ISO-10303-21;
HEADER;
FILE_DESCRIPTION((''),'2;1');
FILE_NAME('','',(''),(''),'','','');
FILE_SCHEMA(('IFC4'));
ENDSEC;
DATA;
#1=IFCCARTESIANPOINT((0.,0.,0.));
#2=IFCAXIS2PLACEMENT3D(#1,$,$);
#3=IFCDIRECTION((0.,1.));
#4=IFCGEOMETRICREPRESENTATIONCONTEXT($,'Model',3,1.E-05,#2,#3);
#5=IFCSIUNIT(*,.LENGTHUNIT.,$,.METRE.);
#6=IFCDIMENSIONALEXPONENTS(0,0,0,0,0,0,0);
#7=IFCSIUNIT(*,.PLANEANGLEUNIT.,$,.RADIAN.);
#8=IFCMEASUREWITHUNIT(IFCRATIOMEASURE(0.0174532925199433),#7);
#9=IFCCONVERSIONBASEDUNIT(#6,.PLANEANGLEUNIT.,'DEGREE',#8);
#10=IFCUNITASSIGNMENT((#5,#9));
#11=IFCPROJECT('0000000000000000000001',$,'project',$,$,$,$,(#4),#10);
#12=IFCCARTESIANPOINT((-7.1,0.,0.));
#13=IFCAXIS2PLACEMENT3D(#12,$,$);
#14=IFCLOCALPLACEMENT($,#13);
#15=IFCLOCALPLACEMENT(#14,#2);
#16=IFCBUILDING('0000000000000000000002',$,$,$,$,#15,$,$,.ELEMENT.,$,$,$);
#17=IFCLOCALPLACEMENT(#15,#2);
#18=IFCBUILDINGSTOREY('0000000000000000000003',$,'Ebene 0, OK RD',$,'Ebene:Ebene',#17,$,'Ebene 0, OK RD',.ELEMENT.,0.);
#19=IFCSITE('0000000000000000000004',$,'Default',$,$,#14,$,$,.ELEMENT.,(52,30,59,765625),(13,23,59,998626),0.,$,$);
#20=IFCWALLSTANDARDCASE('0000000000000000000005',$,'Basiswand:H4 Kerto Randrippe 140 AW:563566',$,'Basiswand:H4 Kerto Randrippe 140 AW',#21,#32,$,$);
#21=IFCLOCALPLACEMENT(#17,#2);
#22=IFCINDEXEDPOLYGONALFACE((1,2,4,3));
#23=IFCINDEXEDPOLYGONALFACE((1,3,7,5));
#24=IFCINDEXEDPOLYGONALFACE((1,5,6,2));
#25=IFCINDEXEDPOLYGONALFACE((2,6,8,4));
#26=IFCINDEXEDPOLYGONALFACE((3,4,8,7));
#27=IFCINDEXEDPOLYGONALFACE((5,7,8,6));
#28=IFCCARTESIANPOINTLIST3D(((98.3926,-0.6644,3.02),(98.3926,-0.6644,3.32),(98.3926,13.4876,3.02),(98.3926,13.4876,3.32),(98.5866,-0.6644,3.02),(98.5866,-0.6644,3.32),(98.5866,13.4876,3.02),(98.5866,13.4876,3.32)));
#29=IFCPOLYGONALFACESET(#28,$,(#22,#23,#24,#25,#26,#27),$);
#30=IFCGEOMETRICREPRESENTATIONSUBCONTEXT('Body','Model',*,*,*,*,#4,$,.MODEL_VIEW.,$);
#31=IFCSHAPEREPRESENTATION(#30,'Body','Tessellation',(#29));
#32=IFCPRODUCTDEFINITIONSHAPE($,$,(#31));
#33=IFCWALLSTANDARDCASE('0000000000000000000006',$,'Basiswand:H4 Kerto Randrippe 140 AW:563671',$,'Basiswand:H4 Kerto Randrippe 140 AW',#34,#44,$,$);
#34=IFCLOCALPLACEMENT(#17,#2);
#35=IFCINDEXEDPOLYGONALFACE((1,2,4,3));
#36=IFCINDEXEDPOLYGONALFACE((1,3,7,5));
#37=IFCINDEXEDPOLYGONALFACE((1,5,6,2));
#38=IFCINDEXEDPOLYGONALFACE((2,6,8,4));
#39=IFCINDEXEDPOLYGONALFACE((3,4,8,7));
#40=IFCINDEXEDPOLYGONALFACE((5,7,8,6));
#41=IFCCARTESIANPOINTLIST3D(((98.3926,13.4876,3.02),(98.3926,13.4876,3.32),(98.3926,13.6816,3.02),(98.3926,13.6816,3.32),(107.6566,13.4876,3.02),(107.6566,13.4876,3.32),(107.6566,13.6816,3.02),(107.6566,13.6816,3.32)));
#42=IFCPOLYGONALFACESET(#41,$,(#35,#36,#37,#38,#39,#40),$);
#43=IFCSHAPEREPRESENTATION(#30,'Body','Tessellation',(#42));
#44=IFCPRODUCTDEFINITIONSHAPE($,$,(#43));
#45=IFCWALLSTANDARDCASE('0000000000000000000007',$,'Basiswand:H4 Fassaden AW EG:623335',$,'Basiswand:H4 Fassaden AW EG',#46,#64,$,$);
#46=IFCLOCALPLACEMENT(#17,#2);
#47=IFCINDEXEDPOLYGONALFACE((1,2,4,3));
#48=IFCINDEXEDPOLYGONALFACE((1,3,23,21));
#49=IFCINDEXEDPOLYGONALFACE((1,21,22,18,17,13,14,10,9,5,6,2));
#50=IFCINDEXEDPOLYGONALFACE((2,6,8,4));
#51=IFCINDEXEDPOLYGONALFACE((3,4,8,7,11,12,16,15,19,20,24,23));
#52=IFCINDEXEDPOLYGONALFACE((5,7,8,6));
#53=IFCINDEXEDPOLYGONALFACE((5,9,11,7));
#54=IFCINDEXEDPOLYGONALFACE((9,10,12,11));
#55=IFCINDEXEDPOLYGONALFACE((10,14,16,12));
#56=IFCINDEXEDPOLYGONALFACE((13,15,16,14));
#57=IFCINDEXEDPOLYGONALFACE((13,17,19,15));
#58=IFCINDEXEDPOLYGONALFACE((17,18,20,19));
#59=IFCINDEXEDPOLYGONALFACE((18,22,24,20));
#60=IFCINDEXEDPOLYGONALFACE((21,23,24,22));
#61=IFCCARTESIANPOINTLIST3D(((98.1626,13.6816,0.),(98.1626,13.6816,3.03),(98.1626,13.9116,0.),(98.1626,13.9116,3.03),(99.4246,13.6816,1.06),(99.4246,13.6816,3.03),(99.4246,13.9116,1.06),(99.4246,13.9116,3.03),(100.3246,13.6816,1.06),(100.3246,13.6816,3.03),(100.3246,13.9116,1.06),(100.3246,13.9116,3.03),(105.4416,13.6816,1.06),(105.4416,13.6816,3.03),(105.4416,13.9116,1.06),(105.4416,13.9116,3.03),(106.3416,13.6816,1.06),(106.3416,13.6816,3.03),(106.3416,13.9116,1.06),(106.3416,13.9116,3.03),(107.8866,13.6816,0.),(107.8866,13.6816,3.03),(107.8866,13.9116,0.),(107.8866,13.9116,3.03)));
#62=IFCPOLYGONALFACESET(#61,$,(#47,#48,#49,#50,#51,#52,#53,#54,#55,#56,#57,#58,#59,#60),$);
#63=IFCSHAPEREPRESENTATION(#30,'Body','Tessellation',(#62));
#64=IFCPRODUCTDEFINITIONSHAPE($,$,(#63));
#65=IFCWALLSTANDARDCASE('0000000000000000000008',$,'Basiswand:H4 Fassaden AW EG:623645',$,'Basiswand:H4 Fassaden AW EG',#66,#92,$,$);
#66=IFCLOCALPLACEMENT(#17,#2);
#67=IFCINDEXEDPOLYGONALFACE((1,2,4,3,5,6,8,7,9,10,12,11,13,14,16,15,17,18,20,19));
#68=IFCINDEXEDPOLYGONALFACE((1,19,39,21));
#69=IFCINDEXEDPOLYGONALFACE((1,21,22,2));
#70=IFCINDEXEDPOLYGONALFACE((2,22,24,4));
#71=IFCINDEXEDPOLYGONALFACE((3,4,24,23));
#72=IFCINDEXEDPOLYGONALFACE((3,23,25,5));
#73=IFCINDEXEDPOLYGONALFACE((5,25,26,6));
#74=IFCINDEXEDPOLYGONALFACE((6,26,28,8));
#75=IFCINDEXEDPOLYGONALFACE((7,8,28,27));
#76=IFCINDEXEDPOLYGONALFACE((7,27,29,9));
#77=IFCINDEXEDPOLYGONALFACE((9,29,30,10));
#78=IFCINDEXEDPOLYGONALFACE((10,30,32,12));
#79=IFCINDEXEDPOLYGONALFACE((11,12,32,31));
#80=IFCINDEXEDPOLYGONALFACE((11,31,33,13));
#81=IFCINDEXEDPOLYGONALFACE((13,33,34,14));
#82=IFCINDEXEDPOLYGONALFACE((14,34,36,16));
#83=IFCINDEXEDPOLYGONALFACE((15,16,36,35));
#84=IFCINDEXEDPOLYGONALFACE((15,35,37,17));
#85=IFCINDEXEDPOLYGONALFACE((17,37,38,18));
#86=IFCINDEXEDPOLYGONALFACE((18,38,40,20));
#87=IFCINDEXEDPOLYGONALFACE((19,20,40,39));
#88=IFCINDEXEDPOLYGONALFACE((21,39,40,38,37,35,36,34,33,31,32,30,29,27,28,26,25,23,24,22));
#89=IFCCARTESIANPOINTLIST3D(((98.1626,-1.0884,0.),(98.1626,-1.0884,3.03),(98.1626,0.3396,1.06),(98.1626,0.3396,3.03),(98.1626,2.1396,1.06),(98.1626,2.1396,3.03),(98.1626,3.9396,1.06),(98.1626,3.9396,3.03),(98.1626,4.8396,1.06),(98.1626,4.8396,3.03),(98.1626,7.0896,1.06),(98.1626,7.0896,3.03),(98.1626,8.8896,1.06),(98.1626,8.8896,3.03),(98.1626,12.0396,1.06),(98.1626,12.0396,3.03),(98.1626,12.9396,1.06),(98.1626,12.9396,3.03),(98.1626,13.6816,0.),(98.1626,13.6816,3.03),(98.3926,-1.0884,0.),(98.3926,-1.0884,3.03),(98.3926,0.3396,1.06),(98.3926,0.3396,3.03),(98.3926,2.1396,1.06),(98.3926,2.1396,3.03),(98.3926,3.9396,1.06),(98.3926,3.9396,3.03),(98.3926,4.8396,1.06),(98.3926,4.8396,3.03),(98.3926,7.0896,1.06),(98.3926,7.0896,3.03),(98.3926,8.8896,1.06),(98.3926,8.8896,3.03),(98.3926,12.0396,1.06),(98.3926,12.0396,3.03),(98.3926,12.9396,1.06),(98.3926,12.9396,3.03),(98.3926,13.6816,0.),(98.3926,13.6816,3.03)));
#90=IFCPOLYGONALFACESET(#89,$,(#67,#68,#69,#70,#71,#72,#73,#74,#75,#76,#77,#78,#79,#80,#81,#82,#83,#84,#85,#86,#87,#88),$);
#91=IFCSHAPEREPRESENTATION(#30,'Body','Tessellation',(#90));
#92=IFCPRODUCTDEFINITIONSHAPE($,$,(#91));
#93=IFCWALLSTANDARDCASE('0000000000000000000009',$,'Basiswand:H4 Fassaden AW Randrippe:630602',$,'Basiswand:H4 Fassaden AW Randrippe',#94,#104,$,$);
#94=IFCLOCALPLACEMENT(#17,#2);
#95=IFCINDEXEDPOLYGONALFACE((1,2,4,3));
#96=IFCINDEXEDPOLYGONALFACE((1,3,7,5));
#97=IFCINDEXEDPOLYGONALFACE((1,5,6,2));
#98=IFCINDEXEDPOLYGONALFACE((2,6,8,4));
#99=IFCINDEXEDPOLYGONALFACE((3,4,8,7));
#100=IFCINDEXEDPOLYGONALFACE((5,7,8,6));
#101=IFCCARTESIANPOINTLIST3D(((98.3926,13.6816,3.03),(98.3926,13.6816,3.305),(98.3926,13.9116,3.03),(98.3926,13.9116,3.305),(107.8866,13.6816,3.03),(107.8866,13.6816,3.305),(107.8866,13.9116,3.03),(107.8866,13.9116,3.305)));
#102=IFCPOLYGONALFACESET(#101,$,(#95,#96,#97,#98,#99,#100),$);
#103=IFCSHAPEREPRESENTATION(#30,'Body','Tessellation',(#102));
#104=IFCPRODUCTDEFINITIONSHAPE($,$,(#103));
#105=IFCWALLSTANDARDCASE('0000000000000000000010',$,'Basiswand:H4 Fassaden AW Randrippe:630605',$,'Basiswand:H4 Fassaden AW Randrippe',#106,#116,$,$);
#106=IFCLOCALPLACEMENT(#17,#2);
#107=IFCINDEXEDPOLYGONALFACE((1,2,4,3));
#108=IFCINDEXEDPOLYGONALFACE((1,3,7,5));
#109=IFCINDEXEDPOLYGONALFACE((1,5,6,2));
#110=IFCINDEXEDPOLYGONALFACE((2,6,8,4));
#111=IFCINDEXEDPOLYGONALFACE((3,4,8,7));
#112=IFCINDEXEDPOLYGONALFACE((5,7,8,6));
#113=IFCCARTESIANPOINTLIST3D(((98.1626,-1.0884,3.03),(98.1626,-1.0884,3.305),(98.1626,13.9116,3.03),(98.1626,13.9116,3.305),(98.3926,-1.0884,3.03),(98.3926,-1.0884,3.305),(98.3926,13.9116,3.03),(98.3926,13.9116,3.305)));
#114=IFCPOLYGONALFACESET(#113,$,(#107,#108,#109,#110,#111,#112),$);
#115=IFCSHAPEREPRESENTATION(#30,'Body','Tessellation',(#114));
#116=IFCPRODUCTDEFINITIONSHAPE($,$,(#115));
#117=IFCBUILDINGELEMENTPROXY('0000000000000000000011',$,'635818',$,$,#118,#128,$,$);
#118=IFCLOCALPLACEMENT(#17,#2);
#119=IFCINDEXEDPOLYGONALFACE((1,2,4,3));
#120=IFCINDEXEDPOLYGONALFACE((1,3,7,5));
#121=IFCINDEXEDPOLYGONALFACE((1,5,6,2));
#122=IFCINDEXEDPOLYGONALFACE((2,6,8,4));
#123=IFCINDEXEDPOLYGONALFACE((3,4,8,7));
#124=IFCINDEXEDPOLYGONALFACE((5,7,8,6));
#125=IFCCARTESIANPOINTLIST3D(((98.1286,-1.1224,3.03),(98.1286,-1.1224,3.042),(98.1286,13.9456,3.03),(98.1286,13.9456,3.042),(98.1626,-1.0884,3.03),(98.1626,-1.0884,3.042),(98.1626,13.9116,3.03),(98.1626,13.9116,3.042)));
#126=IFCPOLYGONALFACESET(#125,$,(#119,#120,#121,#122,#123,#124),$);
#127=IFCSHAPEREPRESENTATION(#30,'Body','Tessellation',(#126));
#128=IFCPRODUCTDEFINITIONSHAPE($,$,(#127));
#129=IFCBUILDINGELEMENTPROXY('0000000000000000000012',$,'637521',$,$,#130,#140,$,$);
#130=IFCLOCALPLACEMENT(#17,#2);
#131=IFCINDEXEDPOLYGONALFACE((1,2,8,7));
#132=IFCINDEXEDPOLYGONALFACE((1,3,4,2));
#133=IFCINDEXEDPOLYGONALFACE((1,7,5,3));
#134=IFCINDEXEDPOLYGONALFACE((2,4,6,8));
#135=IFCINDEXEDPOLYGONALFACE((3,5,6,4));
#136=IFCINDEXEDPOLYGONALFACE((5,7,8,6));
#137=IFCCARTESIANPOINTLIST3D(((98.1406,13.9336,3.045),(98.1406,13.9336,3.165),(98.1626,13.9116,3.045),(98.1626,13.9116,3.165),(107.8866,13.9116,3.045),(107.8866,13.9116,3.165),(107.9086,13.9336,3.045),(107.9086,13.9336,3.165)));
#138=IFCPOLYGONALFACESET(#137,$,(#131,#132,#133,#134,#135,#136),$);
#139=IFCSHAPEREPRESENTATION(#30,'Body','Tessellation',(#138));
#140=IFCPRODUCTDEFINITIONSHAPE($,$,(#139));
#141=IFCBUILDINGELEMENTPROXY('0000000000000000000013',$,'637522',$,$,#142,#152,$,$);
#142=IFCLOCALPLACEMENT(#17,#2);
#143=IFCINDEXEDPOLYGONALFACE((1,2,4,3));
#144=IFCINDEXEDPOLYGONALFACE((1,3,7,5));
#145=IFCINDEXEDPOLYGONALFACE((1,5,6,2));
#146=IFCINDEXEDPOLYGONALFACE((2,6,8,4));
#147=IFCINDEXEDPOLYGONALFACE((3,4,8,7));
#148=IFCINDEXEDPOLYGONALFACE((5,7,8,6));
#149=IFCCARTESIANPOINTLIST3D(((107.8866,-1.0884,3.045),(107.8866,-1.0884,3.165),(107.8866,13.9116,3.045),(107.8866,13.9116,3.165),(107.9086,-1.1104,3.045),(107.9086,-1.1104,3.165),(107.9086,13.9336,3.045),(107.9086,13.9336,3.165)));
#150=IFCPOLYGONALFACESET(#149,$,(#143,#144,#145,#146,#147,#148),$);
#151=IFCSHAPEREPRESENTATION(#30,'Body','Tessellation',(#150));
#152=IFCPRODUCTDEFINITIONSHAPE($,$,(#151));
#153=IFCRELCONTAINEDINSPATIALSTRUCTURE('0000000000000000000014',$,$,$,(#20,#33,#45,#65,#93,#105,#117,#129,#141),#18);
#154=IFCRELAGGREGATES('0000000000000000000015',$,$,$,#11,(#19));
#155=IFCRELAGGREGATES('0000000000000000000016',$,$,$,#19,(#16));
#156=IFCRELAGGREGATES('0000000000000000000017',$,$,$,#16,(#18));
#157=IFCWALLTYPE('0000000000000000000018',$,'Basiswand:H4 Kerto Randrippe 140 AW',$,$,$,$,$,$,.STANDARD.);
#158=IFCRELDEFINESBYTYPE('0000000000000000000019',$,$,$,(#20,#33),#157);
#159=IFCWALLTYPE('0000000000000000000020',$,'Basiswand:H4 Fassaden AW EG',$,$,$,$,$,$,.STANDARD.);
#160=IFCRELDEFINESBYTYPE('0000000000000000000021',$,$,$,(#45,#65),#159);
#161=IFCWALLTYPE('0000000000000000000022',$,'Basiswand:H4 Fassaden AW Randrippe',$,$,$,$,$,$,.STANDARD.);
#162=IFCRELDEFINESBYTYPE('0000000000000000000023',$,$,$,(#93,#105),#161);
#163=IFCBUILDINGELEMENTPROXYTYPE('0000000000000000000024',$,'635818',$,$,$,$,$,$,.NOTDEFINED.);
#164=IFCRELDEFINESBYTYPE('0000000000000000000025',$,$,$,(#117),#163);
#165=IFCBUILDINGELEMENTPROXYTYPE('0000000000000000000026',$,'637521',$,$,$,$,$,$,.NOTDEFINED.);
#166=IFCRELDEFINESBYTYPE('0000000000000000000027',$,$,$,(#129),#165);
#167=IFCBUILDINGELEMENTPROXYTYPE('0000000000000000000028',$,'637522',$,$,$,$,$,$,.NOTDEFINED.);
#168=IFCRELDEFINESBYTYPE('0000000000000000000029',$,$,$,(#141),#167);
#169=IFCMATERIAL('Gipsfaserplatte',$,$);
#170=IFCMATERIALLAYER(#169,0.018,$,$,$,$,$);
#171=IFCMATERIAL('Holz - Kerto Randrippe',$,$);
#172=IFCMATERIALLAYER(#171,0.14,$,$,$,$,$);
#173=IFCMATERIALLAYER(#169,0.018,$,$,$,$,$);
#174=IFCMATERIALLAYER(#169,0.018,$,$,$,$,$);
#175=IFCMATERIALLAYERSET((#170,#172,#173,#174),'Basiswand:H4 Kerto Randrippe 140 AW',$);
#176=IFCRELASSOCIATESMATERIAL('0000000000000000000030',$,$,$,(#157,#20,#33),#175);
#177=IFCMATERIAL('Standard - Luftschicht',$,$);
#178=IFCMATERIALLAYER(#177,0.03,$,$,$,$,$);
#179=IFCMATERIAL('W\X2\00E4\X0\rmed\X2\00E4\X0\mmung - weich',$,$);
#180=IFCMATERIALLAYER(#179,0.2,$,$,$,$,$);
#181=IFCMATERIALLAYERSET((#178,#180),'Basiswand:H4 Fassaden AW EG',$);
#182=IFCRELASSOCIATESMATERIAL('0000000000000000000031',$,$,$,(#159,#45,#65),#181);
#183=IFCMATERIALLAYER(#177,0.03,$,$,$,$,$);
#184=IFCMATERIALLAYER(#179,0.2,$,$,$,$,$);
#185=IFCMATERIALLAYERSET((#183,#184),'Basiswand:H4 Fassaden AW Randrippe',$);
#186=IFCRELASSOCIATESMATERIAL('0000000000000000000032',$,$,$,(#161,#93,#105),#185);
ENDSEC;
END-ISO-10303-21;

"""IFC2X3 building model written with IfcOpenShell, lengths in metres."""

from ifc_helpers import new_model, entity, si_unit, converted_unit, direction, frame, frame_2d, origin, place, context, subcontext, project, spatial, polyline, rectangle, outline, extrude, material, layer, layer_set, layer_usage, type_object, element, save


model = new_model("IFC2X3")

# Units and contexts
model_context = context("Model", 3, precision=1e-05, world=origin(), true_north=direction((0.0, 1.0)))
body_context = subcontext(model_context, "Body", "Model", "MODEL_VIEW")
ifc_project = project(units=[si_unit("LENGTHUNIT", "METRE"), converted_unit("PLANEANGLEUNIT", "DEGREE", entity("IfcRatioMeasure", 0.0174532925199433), si_unit("PLANEANGLEUNIT", "RADIAN"), dimensions=[0, 0, 0, 0, 0, 0, 0])], contexts=[model_context])

# Site, building, storey
site_placement = place(None, frame((-7.1, 0.0, 0.0)))
site = spatial("IfcSite", under=ifc_project, at=site_placement, Name="Default", CompositionType="ELEMENT", RefLatitude=(52, 30, 59, 765625), RefLongitude=(13, 23, 59, 998626), RefElevation=0.0)
building_placement = place(site_placement, origin())
building = spatial("IfcBuilding", under=site, at=building_placement, CompositionType="ELEMENT")
storey_placement = place(building_placement, origin())
storey = spatial("IfcBuildingStorey", under=building, at=storey_placement, Name="Ebene 0, OK RD", ObjectType="Ebene:Ebene", LongName="Ebene 0, OK RD", CompositionType="ELEMENT", Elevation=0.0)

# Shared definitions
ifc_material_1 = material(Name="Gipsfaserplatte")

# Walls
ifc_layer_1 = layer(ifc_material_1, 0.018)
ifc_material_2 = material(Name="Holz - Kerto Randrippe")
ifc_layer_2 = layer(ifc_material_2, 0.14)
ifc_layer_3 = layer(ifc_material_1, 0.018)
ifc_layer_4 = layer(ifc_material_1, 0.018)
ifc_layer_set_1 = layer_set([ifc_layer_1, ifc_layer_2, ifc_layer_3, ifc_layer_4], Name="Basiswand:H4 Kerto Randrippe 140 AW")
ifc_layer_usage_1 = layer_usage(ifc_layer_set_1, "AXIS2", "NEGATIVE", 0.097)
wall_type_1 = type_object("IfcWallType", Name="Basiswand:H4 Kerto Randrippe 140 AW", PredefinedType="STANDARD", material=ifc_layer_set_1)
wall_1_placement = place(storey_placement, frame((98.4896, -0.6644, 3.02), z_axis=(0.0, 0.0, 1.0), x_axis=(0.0, 1.0, 0.0)))
element("IfcWallStandardCase", 1, at=wall_1_placement, inside=storey, type_object=wall_type_1, material=ifc_layer_usage_1, Name="Basiswand:H4 Kerto Randrippe 140 AW:563566", ObjectType="Basiswand:H4 Kerto Randrippe 140 AW", context=body_context, shape_type="SweptSolid", body=[
    extrude(rectangle(XDim=14.152, YDim=0.194, at=frame_2d((7.076, 0.0), x_axis=(-1.0, 0.0))), origin(), (0.0, 0.0, 1.0), 0.3),
])
ifc_layer_usage_2 = layer_usage(ifc_layer_set_1, "AXIS2", "NEGATIVE", 0.097)
wall_2_placement = place(storey_placement, frame((98.3926, 13.5846, 3.02)))
element("IfcWallStandardCase", 2, at=wall_2_placement, inside=storey, type_object=wall_type_1, material=ifc_layer_usage_2, Name="Basiswand:H4 Kerto Randrippe 140 AW:563671", ObjectType="Basiswand:H4 Kerto Randrippe 140 AW", context=body_context, shape_type="SweptSolid", body=[
    extrude(rectangle(XDim=9.264, YDim=0.194, at=frame_2d((4.632, 0.0), x_axis=(-1.0, 0.0))), origin(), (0.0, 0.0, 1.0), 0.3),
])

# Walls, openings
ifc_material_3 = material(Name="Standard - Luftschicht")
ifc_layer_5 = layer(ifc_material_3, 0.03)
ifc_material_4 = material(Name="Wärmedämmung - weich")
ifc_layer_6 = layer(ifc_material_4, 0.2)
ifc_layer_set_2 = layer_set([ifc_layer_5, ifc_layer_6], Name="Basiswand:H4 Fassaden AW EG")
ifc_layer_usage_3 = layer_usage(ifc_layer_set_2, "AXIS2", "NEGATIVE", 0.115)
wall_type_2 = type_object("IfcWallType", Name="Basiswand:H4 Fassaden AW EG", PredefinedType="STANDARD", material=ifc_layer_set_2)
wall_3_placement = place(storey_placement, frame((98.1626, 13.7966, 0.0)))
wall_3 = element("IfcWallStandardCase", 3, at=wall_3_placement, inside=storey, type_object=wall_type_2, material=ifc_layer_usage_3, Name="Basiswand:H4 Fassaden AW EG:623335", ObjectType="Basiswand:H4 Fassaden AW EG", context=body_context, shape_type="SweptSolid", body=[
    extrude(rectangle(XDim=9.724, YDim=0.23, at=frame_2d((4.862, 0.0), x_axis=(-1.0, 0.0))), origin(), (0.0, 0.0, 1.0), 3.03),
])
opening_1_placement = place(wall_3_placement, frame((2.162, 0.115, 1.06)))
element("IfcOpeningElement", 4, at=opening_1_placement, cuts=wall_3, ObjectType="Opening", context=body_context, shape_type="SweptSolid", body=[
    extrude(rectangle(XDim=1.97, YDim=0.9, at=frame_2d((0.985, 0.45), x_axis=(1.0, 0.0))), frame((0.0, 0.0, 0.0), z_axis=(0.0, -1.0, 0.0), x_axis=(0.0, 0.0, 1.0)), (0.0, 0.0, 1.0), 0.23),
])
opening_2_placement = place(wall_3_placement, frame((8.179, 0.115, 1.06)))
element("IfcOpeningElement", 5, at=opening_2_placement, cuts=wall_3, ObjectType="Opening", context=body_context, shape_type="SweptSolid", body=[
    extrude(rectangle(XDim=1.97, YDim=0.9, at=frame_2d((0.985, 0.45), x_axis=(1.0, 0.0))), frame((0.0, 0.0, 0.0), z_axis=(0.0, -1.0, 0.0), x_axis=(0.0, 0.0, 1.0)), (0.0, 0.0, 1.0), 0.23),
])
ifc_layer_usage_4 = layer_usage(ifc_layer_set_2, "AXIS2", "NEGATIVE", 0.115)
wall_4_placement = place(storey_placement, frame((98.2776, -1.0884, 0.0), z_axis=(0.0, 0.0, 1.0), x_axis=(0.0, 1.0, 0.0)))
wall_4 = element("IfcWallStandardCase", 6, at=wall_4_placement, inside=storey, type_object=wall_type_2, material=ifc_layer_usage_4, Name="Basiswand:H4 Fassaden AW EG:623645", ObjectType="Basiswand:H4 Fassaden AW EG", context=body_context, shape_type="SweptSolid", body=[
    extrude(rectangle(XDim=14.77, YDim=0.23, at=frame_2d((7.385, 0.0), x_axis=(-1.0, 0.0))), origin(), (0.0, 0.0, 1.0), 3.03),
])
opening_3_placement = place(wall_4_placement, frame((14.028, 0.115, 1.06)))
element("IfcOpeningElement", 7, at=opening_3_placement, cuts=wall_4, ObjectType="Opening", context=body_context, shape_type="SweptSolid", body=[
    extrude(rectangle(XDim=1.97, YDim=0.9, at=frame_2d((0.985, 0.45), x_axis=(1.0, 0.0))), frame((0.0, 0.0, 0.0), z_axis=(0.0, -1.0, 0.0), x_axis=(0.0, 0.0, 1.0)), (0.0, 0.0, 1.0), 0.23),
])
opening_4_placement = place(wall_4_placement, frame((5.928, 0.115, 1.06)))
element("IfcOpeningElement", 8, at=opening_4_placement, cuts=wall_4, ObjectType="Opening", context=body_context, shape_type="SweptSolid", body=[
    extrude(rectangle(XDim=1.97, YDim=0.9, at=frame_2d((0.985, 0.45), x_axis=(1.0, 0.0))), frame((0.0, 0.0, 0.0), z_axis=(0.0, -1.0, 0.0), x_axis=(0.0, 0.0, 1.0)), (0.0, 0.0, 1.0), 0.23),
])
opening_5_placement = place(wall_4_placement, frame((9.978, 0.115, 1.06)))
element("IfcOpeningElement", 9, at=opening_5_placement, cuts=wall_4, ObjectType="Opening", context=body_context, shape_type="SweptSolid", body=[
    extrude(rectangle(XDim=1.97, YDim=1.8, at=frame_2d((0.985, 0.9), x_axis=(1.0, 0.0))), frame((0.0, 0.0, 0.0), z_axis=(0.0, -1.0, 0.0), x_axis=(0.0, 0.0, 1.0)), (0.0, 0.0, 1.0), 0.23),
])
opening_6_placement = place(wall_4_placement, frame((3.228, 0.115, 1.06)))
element("IfcOpeningElement", 10, at=opening_6_placement, cuts=wall_4, ObjectType="Opening", context=body_context, shape_type="SweptSolid", body=[
    extrude(rectangle(XDim=1.97, YDim=1.8, at=frame_2d((0.985, 0.9), x_axis=(1.0, 0.0))), frame((0.0, 0.0, 0.0), z_axis=(0.0, -1.0, 0.0), x_axis=(0.0, 0.0, 1.0)), (0.0, 0.0, 1.0), 0.23),
])

# Walls
ifc_layer_7 = layer(ifc_material_3, 0.03)
ifc_layer_8 = layer(ifc_material_4, 0.2)
ifc_layer_set_3 = layer_set([ifc_layer_7, ifc_layer_8], Name="Basiswand:H4 Fassaden AW Randrippe")
ifc_layer_usage_5 = layer_usage(ifc_layer_set_3, "AXIS2", "NEGATIVE", 0.115)
wall_type_3 = type_object("IfcWallType", Name="Basiswand:H4 Fassaden AW Randrippe", PredefinedType="STANDARD", material=ifc_layer_set_3)
wall_5_placement = place(storey_placement, frame((98.3926, 13.7966, 3.03)))
element("IfcWallStandardCase", 11, at=wall_5_placement, inside=storey, type_object=wall_type_3, material=ifc_layer_usage_5, Name="Basiswand:H4 Fassaden AW Randrippe:630602", ObjectType="Basiswand:H4 Fassaden AW Randrippe", context=body_context, shape_type="SweptSolid", body=[
    extrude(rectangle(XDim=9.494, YDim=0.23, at=frame_2d((4.747, 0.0), x_axis=(-1.0, 0.0))), origin(), (0.0, 0.0, 1.0), 0.275),
])
ifc_layer_usage_6 = layer_usage(ifc_layer_set_3, "AXIS2", "NEGATIVE", 0.115)
wall_6_placement = place(storey_placement, frame((98.2776, -1.0884, 3.03), z_axis=(0.0, 0.0, 1.0), x_axis=(0.0, 1.0, 0.0)))
element("IfcWallStandardCase", 12, at=wall_6_placement, inside=storey, type_object=wall_type_3, material=ifc_layer_usage_6, Name="Basiswand:H4 Fassaden AW Randrippe:630605", ObjectType="Basiswand:H4 Fassaden AW Randrippe", context=body_context, shape_type="SweptSolid", body=[
    extrude(rectangle(XDim=15.0, YDim=0.23, at=frame_2d((7.5, 0.0), x_axis=(-1.0, 0.0))), origin(), (0.0, 0.0, 1.0), 0.275),
])

# Building element proxies
building_element_proxy_type_1 = type_object("IfcBuildingElementProxyType", Name="635818", PredefinedType="NOTDEFINED")
proxy_1_placement = place(storey_placement, origin())
element("IfcBuildingElementProxy", 13, at=proxy_1_placement, inside=storey, type_object=building_element_proxy_type_1, Name="635818", context=body_context, shape_type="SweptSolid", body=[
    extrude(outline(polyline([(-7.5, -0.017), (7.5, -0.017), (7.534, 0.017), (-7.534, 0.017), (-7.5, -0.017)])), frame((98.1456, 6.4116, 3.03), z_axis=(0.0, 0.0, 1.0), x_axis=(0.0, 1.0, 0.0)), (0.0, 0.0, 1.0), 0.012),
])
building_element_proxy_type_2 = type_object("IfcBuildingElementProxyType", Name="637521", PredefinedType="NOTDEFINED")
proxy_2_placement = place(storey_placement, origin())
element("IfcBuildingElementProxy", 14, at=proxy_2_placement, inside=storey, type_object=building_element_proxy_type_2, Name="637521", context=body_context, shape_type="SweptSolid", body=[
    extrude(outline(polyline([(-4.862, -0.011), (4.862, -0.011), (4.884, 0.011), (-4.884, 0.011), (-4.862, -0.011)])), frame((103.0246, 13.9226, 3.045)), (0.0, 0.0, 1.0), 0.12),
])
building_element_proxy_type_3 = type_object("IfcBuildingElementProxyType", Name="637522", PredefinedType="NOTDEFINED")
proxy_3_placement = place(storey_placement, origin())
element("IfcBuildingElementProxy", 15, at=proxy_3_placement, inside=storey, type_object=building_element_proxy_type_3, Name="637522", context=body_context, shape_type="SweptSolid", body=[
    extrude(outline(polyline([(-7.5, -0.011), (7.5, -0.011), (7.522, 0.011), (-7.522, 0.011), (-7.5, -0.011)])), frame((107.8976, 6.4116, 3.045), z_axis=(0.0, 0.0, 1.0), x_axis=(0.0, -1.0, 0.0)), (0.0, 0.0, 1.0), 0.12),
])

save(model, "model.ifc")
